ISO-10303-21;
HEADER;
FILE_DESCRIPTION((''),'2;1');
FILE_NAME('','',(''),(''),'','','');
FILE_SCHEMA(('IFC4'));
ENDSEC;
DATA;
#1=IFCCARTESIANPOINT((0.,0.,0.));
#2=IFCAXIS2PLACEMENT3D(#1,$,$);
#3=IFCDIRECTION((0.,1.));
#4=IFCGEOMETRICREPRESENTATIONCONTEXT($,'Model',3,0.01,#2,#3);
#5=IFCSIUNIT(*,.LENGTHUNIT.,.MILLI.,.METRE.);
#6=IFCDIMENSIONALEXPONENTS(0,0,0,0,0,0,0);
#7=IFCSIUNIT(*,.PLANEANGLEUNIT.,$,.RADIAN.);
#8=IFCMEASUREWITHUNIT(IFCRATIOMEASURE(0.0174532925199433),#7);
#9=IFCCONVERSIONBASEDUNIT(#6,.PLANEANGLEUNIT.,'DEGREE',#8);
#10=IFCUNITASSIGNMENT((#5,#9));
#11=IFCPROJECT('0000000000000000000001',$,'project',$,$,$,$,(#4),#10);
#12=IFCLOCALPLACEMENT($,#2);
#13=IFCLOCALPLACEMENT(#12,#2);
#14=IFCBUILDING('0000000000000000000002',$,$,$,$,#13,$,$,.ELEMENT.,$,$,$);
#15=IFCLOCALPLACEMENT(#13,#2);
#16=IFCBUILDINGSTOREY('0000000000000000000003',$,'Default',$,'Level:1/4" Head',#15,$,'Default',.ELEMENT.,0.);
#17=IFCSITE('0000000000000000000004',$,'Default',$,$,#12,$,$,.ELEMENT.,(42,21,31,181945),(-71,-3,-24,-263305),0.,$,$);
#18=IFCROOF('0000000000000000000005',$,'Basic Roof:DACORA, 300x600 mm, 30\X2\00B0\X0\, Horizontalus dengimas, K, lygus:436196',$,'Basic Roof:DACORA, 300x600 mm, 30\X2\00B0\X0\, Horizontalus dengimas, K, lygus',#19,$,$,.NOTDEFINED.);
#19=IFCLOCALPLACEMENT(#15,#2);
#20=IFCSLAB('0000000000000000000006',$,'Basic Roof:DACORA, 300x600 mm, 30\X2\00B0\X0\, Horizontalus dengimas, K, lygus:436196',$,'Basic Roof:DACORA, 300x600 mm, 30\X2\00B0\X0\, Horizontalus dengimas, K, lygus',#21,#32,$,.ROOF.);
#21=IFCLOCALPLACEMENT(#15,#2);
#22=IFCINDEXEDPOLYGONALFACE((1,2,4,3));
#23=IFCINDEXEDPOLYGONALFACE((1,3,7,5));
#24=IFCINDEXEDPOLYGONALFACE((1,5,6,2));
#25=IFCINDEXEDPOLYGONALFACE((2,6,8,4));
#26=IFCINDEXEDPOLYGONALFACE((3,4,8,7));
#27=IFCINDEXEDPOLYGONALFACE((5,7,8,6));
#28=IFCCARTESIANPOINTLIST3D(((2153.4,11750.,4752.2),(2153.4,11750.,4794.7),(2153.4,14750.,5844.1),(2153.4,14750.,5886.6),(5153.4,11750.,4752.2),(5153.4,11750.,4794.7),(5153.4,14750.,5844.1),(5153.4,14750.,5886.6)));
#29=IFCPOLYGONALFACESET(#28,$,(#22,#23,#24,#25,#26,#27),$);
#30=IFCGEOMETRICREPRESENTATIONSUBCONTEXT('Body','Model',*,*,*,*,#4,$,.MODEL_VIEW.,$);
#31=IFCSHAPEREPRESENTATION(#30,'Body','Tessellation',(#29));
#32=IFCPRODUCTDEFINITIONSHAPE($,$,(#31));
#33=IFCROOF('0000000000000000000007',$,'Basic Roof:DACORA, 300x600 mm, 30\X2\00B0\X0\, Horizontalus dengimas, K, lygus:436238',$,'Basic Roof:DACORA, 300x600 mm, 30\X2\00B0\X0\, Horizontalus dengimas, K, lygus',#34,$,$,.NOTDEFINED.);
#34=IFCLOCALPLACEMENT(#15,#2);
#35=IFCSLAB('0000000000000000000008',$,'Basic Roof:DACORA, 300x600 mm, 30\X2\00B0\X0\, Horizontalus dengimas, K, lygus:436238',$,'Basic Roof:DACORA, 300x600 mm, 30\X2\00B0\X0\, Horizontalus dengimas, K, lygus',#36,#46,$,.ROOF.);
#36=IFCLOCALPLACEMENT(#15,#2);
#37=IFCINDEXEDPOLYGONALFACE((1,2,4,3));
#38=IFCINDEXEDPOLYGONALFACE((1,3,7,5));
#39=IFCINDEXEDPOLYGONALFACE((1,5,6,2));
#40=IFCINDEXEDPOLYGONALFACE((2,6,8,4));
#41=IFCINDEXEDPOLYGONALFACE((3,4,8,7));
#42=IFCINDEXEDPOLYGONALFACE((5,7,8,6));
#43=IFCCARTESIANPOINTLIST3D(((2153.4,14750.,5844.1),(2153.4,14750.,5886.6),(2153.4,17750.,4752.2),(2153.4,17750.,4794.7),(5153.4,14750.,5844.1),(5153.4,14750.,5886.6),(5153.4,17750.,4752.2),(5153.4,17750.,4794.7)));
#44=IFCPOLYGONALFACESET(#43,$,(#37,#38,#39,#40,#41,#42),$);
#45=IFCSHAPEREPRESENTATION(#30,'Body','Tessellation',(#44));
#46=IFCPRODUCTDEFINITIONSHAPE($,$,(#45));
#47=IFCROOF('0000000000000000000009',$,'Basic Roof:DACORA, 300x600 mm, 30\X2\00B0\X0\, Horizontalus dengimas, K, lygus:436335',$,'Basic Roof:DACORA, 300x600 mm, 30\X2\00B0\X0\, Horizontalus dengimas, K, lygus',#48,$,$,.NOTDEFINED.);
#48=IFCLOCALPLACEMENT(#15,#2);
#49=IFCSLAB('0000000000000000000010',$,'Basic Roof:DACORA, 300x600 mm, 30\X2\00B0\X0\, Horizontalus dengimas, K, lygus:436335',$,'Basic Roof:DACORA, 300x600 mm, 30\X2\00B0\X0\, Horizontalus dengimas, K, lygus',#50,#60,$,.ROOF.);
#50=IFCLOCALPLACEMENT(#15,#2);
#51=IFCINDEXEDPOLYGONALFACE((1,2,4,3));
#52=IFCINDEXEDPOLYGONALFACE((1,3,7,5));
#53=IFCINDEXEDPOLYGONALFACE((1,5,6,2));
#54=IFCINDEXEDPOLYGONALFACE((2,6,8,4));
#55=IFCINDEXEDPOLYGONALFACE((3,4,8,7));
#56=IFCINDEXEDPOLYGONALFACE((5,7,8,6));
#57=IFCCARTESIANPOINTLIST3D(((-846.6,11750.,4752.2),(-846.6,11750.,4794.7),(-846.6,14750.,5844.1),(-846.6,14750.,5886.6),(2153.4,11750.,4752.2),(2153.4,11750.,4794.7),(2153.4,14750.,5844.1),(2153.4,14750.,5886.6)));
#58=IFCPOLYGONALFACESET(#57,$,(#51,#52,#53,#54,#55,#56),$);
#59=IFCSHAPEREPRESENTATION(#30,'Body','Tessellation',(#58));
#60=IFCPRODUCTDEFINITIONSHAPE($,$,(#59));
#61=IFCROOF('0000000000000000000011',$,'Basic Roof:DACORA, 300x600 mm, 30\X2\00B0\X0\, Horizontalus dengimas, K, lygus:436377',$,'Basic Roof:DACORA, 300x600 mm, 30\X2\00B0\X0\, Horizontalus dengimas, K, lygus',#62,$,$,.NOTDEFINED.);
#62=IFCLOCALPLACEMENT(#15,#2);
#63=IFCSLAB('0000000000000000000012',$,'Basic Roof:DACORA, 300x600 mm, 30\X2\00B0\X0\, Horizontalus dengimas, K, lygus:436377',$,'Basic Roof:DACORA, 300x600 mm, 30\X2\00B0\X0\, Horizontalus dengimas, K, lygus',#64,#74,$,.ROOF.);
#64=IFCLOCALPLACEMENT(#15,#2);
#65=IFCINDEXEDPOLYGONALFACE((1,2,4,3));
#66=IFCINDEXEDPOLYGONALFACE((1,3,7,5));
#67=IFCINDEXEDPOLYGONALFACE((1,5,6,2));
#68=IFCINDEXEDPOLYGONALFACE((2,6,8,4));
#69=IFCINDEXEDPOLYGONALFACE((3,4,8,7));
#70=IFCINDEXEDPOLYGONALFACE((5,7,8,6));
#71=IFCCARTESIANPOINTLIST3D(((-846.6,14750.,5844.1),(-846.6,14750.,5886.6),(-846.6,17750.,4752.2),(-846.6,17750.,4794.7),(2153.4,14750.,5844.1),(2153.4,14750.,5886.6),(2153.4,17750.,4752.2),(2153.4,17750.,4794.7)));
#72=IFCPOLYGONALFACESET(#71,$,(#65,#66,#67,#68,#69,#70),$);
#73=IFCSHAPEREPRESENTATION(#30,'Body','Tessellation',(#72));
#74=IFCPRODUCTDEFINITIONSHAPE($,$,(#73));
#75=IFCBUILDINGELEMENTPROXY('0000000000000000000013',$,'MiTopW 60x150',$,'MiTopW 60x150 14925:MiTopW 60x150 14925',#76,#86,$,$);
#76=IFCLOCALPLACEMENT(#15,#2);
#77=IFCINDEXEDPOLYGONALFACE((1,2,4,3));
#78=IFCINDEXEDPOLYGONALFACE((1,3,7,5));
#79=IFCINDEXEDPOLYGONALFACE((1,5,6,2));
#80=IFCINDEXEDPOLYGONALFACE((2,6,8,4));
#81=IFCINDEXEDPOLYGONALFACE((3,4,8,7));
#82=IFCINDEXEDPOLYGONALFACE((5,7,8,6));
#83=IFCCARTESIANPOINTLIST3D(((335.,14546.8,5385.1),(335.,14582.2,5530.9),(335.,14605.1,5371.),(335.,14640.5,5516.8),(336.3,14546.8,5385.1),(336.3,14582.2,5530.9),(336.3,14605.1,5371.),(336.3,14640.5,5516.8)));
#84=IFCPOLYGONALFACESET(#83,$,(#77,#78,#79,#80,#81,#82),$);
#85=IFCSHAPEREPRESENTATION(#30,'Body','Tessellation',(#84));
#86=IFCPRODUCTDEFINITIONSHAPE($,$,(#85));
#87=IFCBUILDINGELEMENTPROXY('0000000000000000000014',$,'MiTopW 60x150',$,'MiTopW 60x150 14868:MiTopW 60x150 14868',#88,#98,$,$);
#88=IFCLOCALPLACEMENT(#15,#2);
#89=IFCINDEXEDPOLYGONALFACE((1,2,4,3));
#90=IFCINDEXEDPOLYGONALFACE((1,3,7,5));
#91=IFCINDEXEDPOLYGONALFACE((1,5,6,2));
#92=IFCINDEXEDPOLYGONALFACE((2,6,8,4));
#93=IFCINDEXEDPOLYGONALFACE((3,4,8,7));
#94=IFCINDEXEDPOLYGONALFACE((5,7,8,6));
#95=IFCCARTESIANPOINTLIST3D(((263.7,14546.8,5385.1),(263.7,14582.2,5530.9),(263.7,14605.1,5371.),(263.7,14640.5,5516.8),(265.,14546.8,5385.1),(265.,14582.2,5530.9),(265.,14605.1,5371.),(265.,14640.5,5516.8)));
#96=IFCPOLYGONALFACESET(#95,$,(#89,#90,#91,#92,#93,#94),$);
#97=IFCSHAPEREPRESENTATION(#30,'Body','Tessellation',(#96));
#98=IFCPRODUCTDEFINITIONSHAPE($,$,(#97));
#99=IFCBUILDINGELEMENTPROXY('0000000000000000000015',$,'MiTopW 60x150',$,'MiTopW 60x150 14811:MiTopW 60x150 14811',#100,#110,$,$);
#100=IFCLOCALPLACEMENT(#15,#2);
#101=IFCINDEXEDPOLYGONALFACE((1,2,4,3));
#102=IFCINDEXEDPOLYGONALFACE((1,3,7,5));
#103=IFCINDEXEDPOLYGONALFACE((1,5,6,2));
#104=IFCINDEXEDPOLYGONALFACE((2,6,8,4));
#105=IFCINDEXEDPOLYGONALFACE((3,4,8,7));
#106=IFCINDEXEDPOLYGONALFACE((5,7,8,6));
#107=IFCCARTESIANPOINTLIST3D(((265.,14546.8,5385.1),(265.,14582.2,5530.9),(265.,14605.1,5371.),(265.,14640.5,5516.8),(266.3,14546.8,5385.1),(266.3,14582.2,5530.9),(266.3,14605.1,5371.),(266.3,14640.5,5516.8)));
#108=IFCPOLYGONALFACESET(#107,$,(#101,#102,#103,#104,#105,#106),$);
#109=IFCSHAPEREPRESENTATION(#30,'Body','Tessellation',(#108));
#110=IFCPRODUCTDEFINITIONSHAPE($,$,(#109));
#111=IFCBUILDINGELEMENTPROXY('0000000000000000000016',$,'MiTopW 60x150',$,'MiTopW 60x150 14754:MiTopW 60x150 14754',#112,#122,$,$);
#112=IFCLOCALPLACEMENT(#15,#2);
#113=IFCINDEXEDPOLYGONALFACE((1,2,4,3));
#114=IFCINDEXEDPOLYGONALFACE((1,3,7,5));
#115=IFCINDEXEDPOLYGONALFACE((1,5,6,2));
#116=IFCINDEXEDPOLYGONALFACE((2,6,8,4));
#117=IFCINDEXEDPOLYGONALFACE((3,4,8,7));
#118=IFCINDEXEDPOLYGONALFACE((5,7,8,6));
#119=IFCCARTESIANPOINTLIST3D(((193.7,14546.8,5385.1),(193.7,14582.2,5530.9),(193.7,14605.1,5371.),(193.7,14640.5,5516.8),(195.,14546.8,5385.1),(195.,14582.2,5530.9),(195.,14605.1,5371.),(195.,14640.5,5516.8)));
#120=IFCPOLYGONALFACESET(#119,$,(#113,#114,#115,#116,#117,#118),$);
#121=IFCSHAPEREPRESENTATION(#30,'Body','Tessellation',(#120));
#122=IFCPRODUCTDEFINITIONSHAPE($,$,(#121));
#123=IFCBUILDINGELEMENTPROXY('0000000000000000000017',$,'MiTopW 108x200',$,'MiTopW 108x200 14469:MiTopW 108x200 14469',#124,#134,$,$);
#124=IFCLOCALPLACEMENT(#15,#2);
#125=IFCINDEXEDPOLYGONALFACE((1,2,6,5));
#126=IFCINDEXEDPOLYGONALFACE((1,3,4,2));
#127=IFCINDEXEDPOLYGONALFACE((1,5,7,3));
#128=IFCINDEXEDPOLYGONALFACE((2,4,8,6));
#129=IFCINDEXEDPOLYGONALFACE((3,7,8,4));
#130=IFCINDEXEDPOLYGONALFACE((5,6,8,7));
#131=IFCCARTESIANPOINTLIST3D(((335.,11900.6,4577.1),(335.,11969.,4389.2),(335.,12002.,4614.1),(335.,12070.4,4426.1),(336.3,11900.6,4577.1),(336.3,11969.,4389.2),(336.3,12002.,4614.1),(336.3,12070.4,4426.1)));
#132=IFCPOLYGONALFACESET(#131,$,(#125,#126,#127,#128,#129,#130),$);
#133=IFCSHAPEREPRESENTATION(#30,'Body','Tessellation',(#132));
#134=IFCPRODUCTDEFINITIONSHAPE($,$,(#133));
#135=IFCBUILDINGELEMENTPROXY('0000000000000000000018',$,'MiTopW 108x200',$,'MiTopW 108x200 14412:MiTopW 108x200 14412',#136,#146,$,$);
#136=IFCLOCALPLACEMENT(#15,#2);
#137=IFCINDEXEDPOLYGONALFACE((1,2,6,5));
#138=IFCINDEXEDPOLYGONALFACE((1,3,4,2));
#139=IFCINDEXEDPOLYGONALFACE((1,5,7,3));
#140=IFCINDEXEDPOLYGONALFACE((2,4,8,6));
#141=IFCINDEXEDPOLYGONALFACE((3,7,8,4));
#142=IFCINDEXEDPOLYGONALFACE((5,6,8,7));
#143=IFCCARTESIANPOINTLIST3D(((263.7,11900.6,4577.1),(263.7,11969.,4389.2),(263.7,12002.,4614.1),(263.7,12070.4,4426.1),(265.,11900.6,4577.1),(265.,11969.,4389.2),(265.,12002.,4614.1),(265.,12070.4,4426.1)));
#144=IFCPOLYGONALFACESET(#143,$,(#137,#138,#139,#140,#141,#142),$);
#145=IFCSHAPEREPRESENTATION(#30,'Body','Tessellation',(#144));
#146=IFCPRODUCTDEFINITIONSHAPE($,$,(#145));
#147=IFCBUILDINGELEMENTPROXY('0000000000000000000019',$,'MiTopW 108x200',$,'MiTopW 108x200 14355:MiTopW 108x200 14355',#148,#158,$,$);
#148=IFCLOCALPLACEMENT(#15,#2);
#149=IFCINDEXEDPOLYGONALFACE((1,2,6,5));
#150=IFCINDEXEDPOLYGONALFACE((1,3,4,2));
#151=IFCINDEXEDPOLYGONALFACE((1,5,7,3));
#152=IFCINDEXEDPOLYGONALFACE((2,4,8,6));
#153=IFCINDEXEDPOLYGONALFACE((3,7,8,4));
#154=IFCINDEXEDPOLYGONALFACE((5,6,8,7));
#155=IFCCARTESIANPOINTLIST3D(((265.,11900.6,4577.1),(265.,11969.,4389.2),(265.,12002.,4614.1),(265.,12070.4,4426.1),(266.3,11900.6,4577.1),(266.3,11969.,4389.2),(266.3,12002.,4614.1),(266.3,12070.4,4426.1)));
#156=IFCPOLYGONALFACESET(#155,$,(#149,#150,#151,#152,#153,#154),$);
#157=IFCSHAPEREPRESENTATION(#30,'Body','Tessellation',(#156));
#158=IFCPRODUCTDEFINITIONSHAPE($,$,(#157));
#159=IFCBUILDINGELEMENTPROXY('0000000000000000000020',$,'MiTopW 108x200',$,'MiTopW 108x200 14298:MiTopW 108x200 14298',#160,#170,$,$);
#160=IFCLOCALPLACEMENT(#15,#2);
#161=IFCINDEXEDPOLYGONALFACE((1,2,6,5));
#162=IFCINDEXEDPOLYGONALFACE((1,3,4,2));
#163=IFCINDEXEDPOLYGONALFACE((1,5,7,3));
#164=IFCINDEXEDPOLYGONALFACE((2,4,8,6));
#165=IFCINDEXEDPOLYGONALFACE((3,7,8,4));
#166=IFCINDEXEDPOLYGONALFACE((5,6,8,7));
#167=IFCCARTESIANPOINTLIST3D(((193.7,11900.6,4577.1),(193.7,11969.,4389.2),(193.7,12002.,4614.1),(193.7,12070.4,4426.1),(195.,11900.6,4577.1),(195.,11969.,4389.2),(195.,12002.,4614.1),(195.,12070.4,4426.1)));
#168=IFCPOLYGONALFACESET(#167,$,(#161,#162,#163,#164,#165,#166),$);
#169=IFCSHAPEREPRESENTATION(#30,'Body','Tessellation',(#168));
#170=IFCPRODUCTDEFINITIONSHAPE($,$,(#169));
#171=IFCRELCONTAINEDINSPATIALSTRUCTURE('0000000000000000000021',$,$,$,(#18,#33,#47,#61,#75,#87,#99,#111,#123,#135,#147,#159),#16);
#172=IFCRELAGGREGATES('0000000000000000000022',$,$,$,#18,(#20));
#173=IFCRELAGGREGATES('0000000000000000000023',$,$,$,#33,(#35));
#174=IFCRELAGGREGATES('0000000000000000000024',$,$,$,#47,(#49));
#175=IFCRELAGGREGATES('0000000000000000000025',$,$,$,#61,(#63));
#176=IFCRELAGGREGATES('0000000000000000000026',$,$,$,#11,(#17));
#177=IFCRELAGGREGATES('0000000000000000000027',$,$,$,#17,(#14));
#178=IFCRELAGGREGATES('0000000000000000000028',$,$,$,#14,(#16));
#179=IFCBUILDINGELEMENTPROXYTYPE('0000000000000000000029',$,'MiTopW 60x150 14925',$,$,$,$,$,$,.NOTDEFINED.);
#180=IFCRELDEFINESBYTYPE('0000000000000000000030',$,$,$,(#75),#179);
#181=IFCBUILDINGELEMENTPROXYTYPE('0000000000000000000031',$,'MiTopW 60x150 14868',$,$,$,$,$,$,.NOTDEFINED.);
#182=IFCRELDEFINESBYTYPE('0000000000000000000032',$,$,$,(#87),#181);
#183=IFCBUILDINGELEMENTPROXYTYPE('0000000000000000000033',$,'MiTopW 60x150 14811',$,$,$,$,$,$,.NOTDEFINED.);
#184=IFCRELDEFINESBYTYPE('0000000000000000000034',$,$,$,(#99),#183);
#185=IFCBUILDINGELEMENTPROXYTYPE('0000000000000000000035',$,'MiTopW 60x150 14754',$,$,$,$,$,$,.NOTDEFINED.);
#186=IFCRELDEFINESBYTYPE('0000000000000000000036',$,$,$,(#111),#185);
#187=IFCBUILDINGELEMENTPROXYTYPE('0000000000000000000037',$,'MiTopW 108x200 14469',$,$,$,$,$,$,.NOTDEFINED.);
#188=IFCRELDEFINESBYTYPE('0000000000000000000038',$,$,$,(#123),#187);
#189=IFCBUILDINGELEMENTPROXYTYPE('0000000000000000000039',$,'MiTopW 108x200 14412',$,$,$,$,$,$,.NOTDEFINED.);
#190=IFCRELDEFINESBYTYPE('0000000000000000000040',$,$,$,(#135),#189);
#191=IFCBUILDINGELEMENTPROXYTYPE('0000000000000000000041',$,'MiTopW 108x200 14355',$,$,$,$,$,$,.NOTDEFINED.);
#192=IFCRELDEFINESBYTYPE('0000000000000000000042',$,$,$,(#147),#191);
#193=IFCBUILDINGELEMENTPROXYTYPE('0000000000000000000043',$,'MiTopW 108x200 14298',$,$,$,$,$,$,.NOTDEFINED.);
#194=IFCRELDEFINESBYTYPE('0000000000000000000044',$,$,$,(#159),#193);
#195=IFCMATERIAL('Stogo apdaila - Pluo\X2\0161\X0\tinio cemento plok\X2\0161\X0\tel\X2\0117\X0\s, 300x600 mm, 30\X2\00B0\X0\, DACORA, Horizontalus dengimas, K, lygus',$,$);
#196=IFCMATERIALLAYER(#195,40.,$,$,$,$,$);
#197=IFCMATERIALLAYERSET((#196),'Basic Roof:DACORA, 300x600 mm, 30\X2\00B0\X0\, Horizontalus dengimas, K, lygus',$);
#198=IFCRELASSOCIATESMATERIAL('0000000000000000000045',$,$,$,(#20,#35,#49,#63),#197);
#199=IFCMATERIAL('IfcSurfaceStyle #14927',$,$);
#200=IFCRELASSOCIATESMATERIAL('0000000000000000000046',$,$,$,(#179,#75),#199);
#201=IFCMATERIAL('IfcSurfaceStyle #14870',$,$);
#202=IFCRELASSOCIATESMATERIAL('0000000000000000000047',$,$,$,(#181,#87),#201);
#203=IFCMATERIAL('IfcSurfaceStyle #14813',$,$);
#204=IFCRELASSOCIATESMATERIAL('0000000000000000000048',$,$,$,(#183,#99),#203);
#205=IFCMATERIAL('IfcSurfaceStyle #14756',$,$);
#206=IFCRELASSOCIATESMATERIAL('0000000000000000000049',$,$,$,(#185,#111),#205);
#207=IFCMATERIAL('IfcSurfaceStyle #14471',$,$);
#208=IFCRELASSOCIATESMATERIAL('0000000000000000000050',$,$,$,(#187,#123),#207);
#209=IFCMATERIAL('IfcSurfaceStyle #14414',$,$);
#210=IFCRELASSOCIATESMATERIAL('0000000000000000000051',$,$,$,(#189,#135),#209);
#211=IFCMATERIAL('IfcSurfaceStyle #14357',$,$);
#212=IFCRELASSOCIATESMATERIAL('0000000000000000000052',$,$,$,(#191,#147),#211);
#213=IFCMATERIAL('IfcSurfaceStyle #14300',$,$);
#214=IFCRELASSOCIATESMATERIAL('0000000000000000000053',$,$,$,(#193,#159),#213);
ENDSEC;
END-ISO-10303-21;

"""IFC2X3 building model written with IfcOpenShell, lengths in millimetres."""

from ifc_helpers import new_model, entity, si_unit, converted_unit, direction, frame, frame_2d, origin, place, context, subcontext, project, spatial, polyline, rectangle, outline, extrude, source, transform, mapped, material, layer, layer_set, type_object, type_shapes, element, aggregate, save


model = new_model("IFC2X3")

# Units and contexts
model_context = context("Model", 3, precision=0.01, world=origin(), true_north=direction((0.0, 1.0)))
body_context = subcontext(model_context, "Body", "Model", "MODEL_VIEW")
ifc_project = project(units=[si_unit("LENGTHUNIT", "METRE", prefix="MILLI"), converted_unit("PLANEANGLEUNIT", "DEGREE", entity("IfcRatioMeasure", 0.0174532925199433), si_unit("PLANEANGLEUNIT", "RADIAN"), dimensions=[0, 0, 0, 0, 0, 0, 0])], contexts=[model_context])

# Site, building, storey
site_placement = place(None, origin())
site = spatial("IfcSite", under=ifc_project, at=site_placement, Name="Default", CompositionType="ELEMENT", RefLatitude=(42, 21, 31, 181945), RefLongitude=(-71, -3, -24, -263305), RefElevation=0.0)
building_placement = place(site_placement, origin())
building = spatial("IfcBuilding", under=site, at=building_placement, CompositionType="ELEMENT")
storey_placement = place(building_placement, origin())
storey = spatial("IfcBuildingStorey", under=building, at=storey_placement, Name="Default", ObjectType="Level:1/4\" Head", LongName="Default", CompositionType="ELEMENT", Elevation=0.0)

# Roofs, slabs
roof_1_placement = place(storey_placement, frame((2153.4, 11750.0, 4752.2)))
roof_1 = element("IfcRoof", 1, at=roof_1_placement, inside=storey, Name="Basic Roof:DACORA, 300x600 mm, 30°, Horizontalus dengimas, K, lygus:436196", ObjectType="Basic Roof:DACORA, 300x600 mm, 30°, Horizontalus dengimas, K, lygus", ShapeType="NOTDEFINED")
ifc_material_1 = material(Name="Stogo apdaila - Pluoštinio cemento plokštelės, 300x600 mm, 30°, DACORA, Horizontalus dengimas, K, lygus")
ifc_layer = layer(ifc_material_1, 40.0)
ifc_layer_set = layer_set([ifc_layer], Name="Basic Roof:DACORA, 300x600 mm, 30°, Horizontalus dengimas, K, lygus")
slab_1_placement = place(roof_1_placement, origin())
slab_1 = element("IfcSlab", 2, at=slab_1_placement, material=ifc_layer_set, Name="Basic Roof:DACORA, 300x600 mm, 30°, Horizontalus dengimas, K, lygus:436196", ObjectType="Basic Roof:DACORA, 300x600 mm, 30°, Horizontalus dengimas, K, lygus", PredefinedType="ROOF", context=body_context, shape_type="SweptSolid", body=[
    extrude(rectangle(XDim=3192.5, YDim=3000.0, at=frame_2d((0.0, 0.0), x_axis=(0.0, -1.0))), frame((1500.0, 1500.0, 546.0), z_axis=(0.0, -0.34202, 0.939693), x_axis=(1.0, 0.0, 0.0)), (0.0, 0.34202, 0.939693), 42.6),
])
aggregate(roof_1, [slab_1])
roof_2_placement = place(storey_placement, frame((2153.4, 14750.0, 4752.2)))
roof_2 = element("IfcRoof", 3, at=roof_2_placement, inside=storey, Name="Basic Roof:DACORA, 300x600 mm, 30°, Horizontalus dengimas, K, lygus:436238", ObjectType="Basic Roof:DACORA, 300x600 mm, 30°, Horizontalus dengimas, K, lygus", ShapeType="NOTDEFINED")
slab_2_placement = place(roof_2_placement, origin())
slab_2 = element("IfcSlab", 4, at=slab_2_placement, material=ifc_layer_set, Name="Basic Roof:DACORA, 300x600 mm, 30°, Horizontalus dengimas, K, lygus:436238", ObjectType="Basic Roof:DACORA, 300x600 mm, 30°, Horizontalus dengimas, K, lygus", PredefinedType="ROOF", context=body_context, shape_type="SweptSolid", body=[
    extrude(rectangle(XDim=3192.5, YDim=3000.0, at=frame_2d((0.0, 0.0), x_axis=(0.0, 1.0))), frame((1500.0, 1500.0, 546.0), z_axis=(0.0, 0.34202, 0.939693), x_axis=(1.0, 0.0, 0.0)), (0.0, -0.34202, 0.939693), 42.6),
])
aggregate(roof_2, [slab_2])
roof_3_placement = place(storey_placement, frame((-846.6, 11750.0, 4752.2)))
roof_3 = element("IfcRoof", 5, at=roof_3_placement, inside=storey, Name="Basic Roof:DACORA, 300x600 mm, 30°, Horizontalus dengimas, K, lygus:436335", ObjectType="Basic Roof:DACORA, 300x600 mm, 30°, Horizontalus dengimas, K, lygus", ShapeType="NOTDEFINED")
slab_3_placement = place(roof_3_placement, origin())
slab_3 = element("IfcSlab", 6, at=slab_3_placement, material=ifc_layer_set, Name="Basic Roof:DACORA, 300x600 mm, 30°, Horizontalus dengimas, K, lygus:436335", ObjectType="Basic Roof:DACORA, 300x600 mm, 30°, Horizontalus dengimas, K, lygus", PredefinedType="ROOF", context=body_context, shape_type="SweptSolid", body=[
    extrude(rectangle(XDim=3192.5, YDim=3000.0, at=frame_2d((0.0, 0.0), x_axis=(0.0, -1.0))), frame((1500.0, 1500.0, 546.0), z_axis=(0.0, -0.34202, 0.939693), x_axis=(1.0, 0.0, 0.0)), (0.0, 0.34202, 0.939693), 42.6),
])
aggregate(roof_3, [slab_3])
roof_4_placement = place(storey_placement, frame((-846.6, 14750.0, 4752.2)))
roof_4 = element("IfcRoof", 7, at=roof_4_placement, inside=storey, Name="Basic Roof:DACORA, 300x600 mm, 30°, Horizontalus dengimas, K, lygus:436377", ObjectType="Basic Roof:DACORA, 300x600 mm, 30°, Horizontalus dengimas, K, lygus", ShapeType="NOTDEFINED")
slab_4_placement = place(roof_4_placement, origin())
slab_4 = element("IfcSlab", 8, at=slab_4_placement, material=ifc_layer_set, Name="Basic Roof:DACORA, 300x600 mm, 30°, Horizontalus dengimas, K, lygus:436377", ObjectType="Basic Roof:DACORA, 300x600 mm, 30°, Horizontalus dengimas, K, lygus", PredefinedType="ROOF", context=body_context, shape_type="SweptSolid", body=[
    extrude(rectangle(XDim=3192.5, YDim=3000.0, at=frame_2d((0.0, 0.0), x_axis=(0.0, 1.0))), frame((1500.0, 1500.0, 546.0), z_axis=(0.0, 0.34202, 0.939693), x_axis=(1.0, 0.0, 0.0)), (0.0, -0.34202, 0.939693), 42.6),
])
aggregate(roof_4, [slab_4])

# Building element proxies
ifc_material_2 = material(Name="IfcSurfaceStyle #14927")
building_element_proxy_type_1 = type_object("IfcBuildingElementProxyType", Name="MiTopW 60x150 14925", PredefinedType="NOTDEFINED", material=ifc_material_2)
shared_shape_1 = source(origin(), body_context, "Body", "SweptSolid", [
    extrude(outline(polyline([(-75.0, -30.0), (75.0, -30.0), (75.0, 30.0), (-75.0, 30.0), (-75.0, -30.0)])), frame((75.0, 30.0, 0.0), z_axis=(0.0, 0.0, 1.0), x_axis=(-1.0, 0.0, 0.0)), (0.0, 0.0, 1.0), 1.3),
])
type_shapes(building_element_proxy_type_1, [shared_shape_1])
proxy_1_placement = place(building_placement, frame((336.3, 14640.5, 5516.8), z_axis=(-1.0, 0.0, 0.0), x_axis=(0.0, -0.235626, -0.971844)))
element("IfcBuildingElementProxy", 9, at=proxy_1_placement, inside=storey, type_object=building_element_proxy_type_1, material=ifc_material_2, Name="MiTopW 60x150", ObjectType="MiTopW 60x150 14925:MiTopW 60x150 14925", context=body_context, shape_type="MappedRepresentation", body=[
    mapped(shared_shape_1, transform((0.0, 0.0, 0.0), scale=1.0)),
])
ifc_material_3 = material(Name="IfcSurfaceStyle #14870")
building_element_proxy_type_2 = type_object("IfcBuildingElementProxyType", Name="MiTopW 60x150 14868", PredefinedType="NOTDEFINED", material=ifc_material_3)
shared_shape_2 = source(origin(), body_context, "Body", "SweptSolid", [
    extrude(outline(polyline([(-75.0, -30.0), (75.0, -30.0), (75.0, 30.0), (-75.0, 30.0), (-75.0, -30.0)])), frame((75.0, 30.0, 0.0), z_axis=(0.0, 0.0, 1.0), x_axis=(-1.0, 0.0, 0.0)), (0.0, 0.0, 1.0), 1.3),
])
type_shapes(building_element_proxy_type_2, [shared_shape_2])
proxy_2_placement = place(building_placement, frame((265.0, 14640.5, 5516.8), z_axis=(-1.0, 0.0, 0.0), x_axis=(0.0, -0.235626, -0.971844)))
element("IfcBuildingElementProxy", 10, at=proxy_2_placement, inside=storey, type_object=building_element_proxy_type_2, material=ifc_material_3, Name="MiTopW 60x150", ObjectType="MiTopW 60x150 14868:MiTopW 60x150 14868", context=body_context, shape_type="MappedRepresentation", body=[
    mapped(shared_shape_2, transform((0.0, 0.0, 0.0), scale=1.0)),
])
ifc_material_4 = material(Name="IfcSurfaceStyle #14813")
building_element_proxy_type_3 = type_object("IfcBuildingElementProxyType", Name="MiTopW 60x150 14811", PredefinedType="NOTDEFINED", material=ifc_material_4)
shared_shape_3 = source(origin(), body_context, "Body", "SweptSolid", [
    extrude(outline(polyline([(-75.0, -30.0), (75.0, -30.0), (75.0, 30.0), (-75.0, 30.0), (-75.0, -30.0)])), frame((75.0, 30.0, 0.0), z_axis=(0.0, 0.0, 1.0), x_axis=(-1.0, 0.0, 0.0)), (0.0, 0.0, 1.0), 1.3),
])
type_shapes(building_element_proxy_type_3, [shared_shape_3])
proxy_3_placement = place(building_placement, frame((266.3, 14640.5, 5516.8), z_axis=(-1.0, 0.0, 0.0), x_axis=(0.0, -0.235626, -0.971844)))
element("IfcBuildingElementProxy", 11, at=proxy_3_placement, inside=storey, type_object=building_element_proxy_type_3, material=ifc_material_4, Name="MiTopW 60x150", ObjectType="MiTopW 60x150 14811:MiTopW 60x150 14811", context=body_context, shape_type="MappedRepresentation", body=[
    mapped(shared_shape_3, transform((0.0, 0.0, 0.0), scale=1.0)),
])
ifc_material_5 = material(Name="IfcSurfaceStyle #14756")
building_element_proxy_type_4 = type_object("IfcBuildingElementProxyType", Name="MiTopW 60x150 14754", PredefinedType="NOTDEFINED", material=ifc_material_5)
shared_shape_4 = source(origin(), body_context, "Body", "SweptSolid", [
    extrude(outline(polyline([(-75.0, -30.0), (75.0, -30.0), (75.0, 30.0), (-75.0, 30.0), (-75.0, -30.0)])), frame((75.0, 30.0, 0.0), z_axis=(0.0, 0.0, 1.0), x_axis=(-1.0, 0.0, 0.0)), (0.0, 0.0, 1.0), 1.3),
])
type_shapes(building_element_proxy_type_4, [shared_shape_4])
proxy_4_placement = place(building_placement, frame((195.0, 14640.5, 5516.8), z_axis=(-1.0, 0.0, 0.0), x_axis=(0.0, -0.235626, -0.971844)))
element("IfcBuildingElementProxy", 12, at=proxy_4_placement, inside=storey, type_object=building_element_proxy_type_4, material=ifc_material_5, Name="MiTopW 60x150", ObjectType="MiTopW 60x150 14754:MiTopW 60x150 14754", context=body_context, shape_type="MappedRepresentation", body=[
    mapped(shared_shape_4, transform((0.0, 0.0, 0.0), scale=1.0)),
])
ifc_material_6 = material(Name="IfcSurfaceStyle #14471")
building_element_proxy_type_5 = type_object("IfcBuildingElementProxyType", Name="MiTopW 108x200 14469", PredefinedType="NOTDEFINED", material=ifc_material_6)
shared_shape_5 = source(origin(), body_context, "Body", "SweptSolid", [
    extrude(outline(polyline([(-54.0, -100.0), (54.0, -100.0), (54.0, 100.0), (-54.0, 100.0), (-54.0, -100.0)])), frame((100.0, 54.0, 0.0), z_axis=(0.0, 0.0, 1.0), x_axis=(-0.000002, 1.0, 0.0)), (0.0, 0.0, 1.0), 1.3),
])
type_shapes(building_element_proxy_type_5, [shared_shape_5])
proxy_5_placement = place(building_placement, frame((336.3, 12002.0, 4614.1), z_axis=(-1.0, 0.0, 0.0), x_axis=(0.0, 0.34202, -0.939693)))
element("IfcBuildingElementProxy", 13, at=proxy_5_placement, inside=storey, type_object=building_element_proxy_type_5, material=ifc_material_6, Name="MiTopW 108x200", ObjectType="MiTopW 108x200 14469:MiTopW 108x200 14469", context=body_context, shape_type="MappedRepresentation", body=[
    mapped(shared_shape_5, transform((0.0, 0.0, 0.0), scale=1.0)),
])
ifc_material_7 = material(Name="IfcSurfaceStyle #14414")
building_element_proxy_type_6 = type_object("IfcBuildingElementProxyType", Name="MiTopW 108x200 14412", PredefinedType="NOTDEFINED", material=ifc_material_7)
shared_shape_6 = source(origin(), body_context, "Body", "SweptSolid", [
    extrude(outline(polyline([(-54.0, -100.0), (54.0, -100.0), (54.0, 100.0), (-54.0, 100.0), (-54.0, -100.0)])), frame((100.0, 54.0, 0.0), z_axis=(0.0, 0.0, 1.0), x_axis=(-0.000002, 1.0, 0.0)), (0.0, 0.0, 1.0), 1.3),
])
type_shapes(building_element_proxy_type_6, [shared_shape_6])
proxy_6_placement = place(building_placement, frame((265.0, 12002.0, 4614.1), z_axis=(-1.0, 0.0, 0.0), x_axis=(0.0, 0.34202, -0.939693)))
element("IfcBuildingElementProxy", 14, at=proxy_6_placement, inside=storey, type_object=building_element_proxy_type_6, material=ifc_material_7, Name="MiTopW 108x200", ObjectType="MiTopW 108x200 14412:MiTopW 108x200 14412", context=body_context, shape_type="MappedRepresentation", body=[
    mapped(shared_shape_6, transform((0.0, 0.0, 0.0), scale=1.0)),
])
ifc_material_8 = material(Name="IfcSurfaceStyle #14357")
building_element_proxy_type_7 = type_object("IfcBuildingElementProxyType", Name="MiTopW 108x200 14355", PredefinedType="NOTDEFINED", material=ifc_material_8)
shared_shape_7 = source(origin(), body_context, "Body", "SweptSolid", [
    extrude(outline(polyline([(-54.0, -100.0), (54.0, -100.0), (54.0, 100.0), (-54.0, 100.0), (-54.0, -100.0)])), frame((100.0, 54.0, 0.0), z_axis=(0.0, 0.0, 1.0), x_axis=(-0.000002, 1.0, 0.0)), (0.0, 0.0, 1.0), 1.3),
])
type_shapes(building_element_proxy_type_7, [shared_shape_7])
proxy_7_placement = place(building_placement, frame((266.3, 12002.0, 4614.1), z_axis=(-1.0, 0.0, 0.0), x_axis=(0.0, 0.34202, -0.939693)))
element("IfcBuildingElementProxy", 15, at=proxy_7_placement, inside=storey, type_object=building_element_proxy_type_7, material=ifc_material_8, Name="MiTopW 108x200", ObjectType="MiTopW 108x200 14355:MiTopW 108x200 14355", context=body_context, shape_type="MappedRepresentation", body=[
    mapped(shared_shape_7, transform((0.0, 0.0, 0.0), scale=1.0)),
])
ifc_material_9 = material(Name="IfcSurfaceStyle #14300")
building_element_proxy_type_8 = type_object("IfcBuildingElementProxyType", Name="MiTopW 108x200 14298", PredefinedType="NOTDEFINED", material=ifc_material_9)
shared_shape_8 = source(origin(), body_context, "Body", "SweptSolid", [
    extrude(outline(polyline([(-54.0, -100.0), (54.0, -100.0), (54.0, 100.0), (-54.0, 100.0), (-54.0, -100.0)])), frame((100.0, 54.0, 0.0), z_axis=(0.0, 0.0, 1.0), x_axis=(-0.000002, 1.0, 0.0)), (0.0, 0.0, 1.0), 1.3),
])
type_shapes(building_element_proxy_type_8, [shared_shape_8])
proxy_8_placement = place(building_placement, frame((195.0, 12002.0, 4614.1), z_axis=(-1.0, 0.0, 0.0), x_axis=(0.0, 0.34202, -0.939693)))
element("IfcBuildingElementProxy", 16, at=proxy_8_placement, inside=storey, type_object=building_element_proxy_type_8, material=ifc_material_9, Name="MiTopW 108x200", ObjectType="MiTopW 108x200 14298:MiTopW 108x200 14298", context=body_context, shape_type="MappedRepresentation", body=[
    mapped(shared_shape_8, transform((0.0, 0.0, 0.0), scale=1.0)),
])

save(model, "model.ifc")
